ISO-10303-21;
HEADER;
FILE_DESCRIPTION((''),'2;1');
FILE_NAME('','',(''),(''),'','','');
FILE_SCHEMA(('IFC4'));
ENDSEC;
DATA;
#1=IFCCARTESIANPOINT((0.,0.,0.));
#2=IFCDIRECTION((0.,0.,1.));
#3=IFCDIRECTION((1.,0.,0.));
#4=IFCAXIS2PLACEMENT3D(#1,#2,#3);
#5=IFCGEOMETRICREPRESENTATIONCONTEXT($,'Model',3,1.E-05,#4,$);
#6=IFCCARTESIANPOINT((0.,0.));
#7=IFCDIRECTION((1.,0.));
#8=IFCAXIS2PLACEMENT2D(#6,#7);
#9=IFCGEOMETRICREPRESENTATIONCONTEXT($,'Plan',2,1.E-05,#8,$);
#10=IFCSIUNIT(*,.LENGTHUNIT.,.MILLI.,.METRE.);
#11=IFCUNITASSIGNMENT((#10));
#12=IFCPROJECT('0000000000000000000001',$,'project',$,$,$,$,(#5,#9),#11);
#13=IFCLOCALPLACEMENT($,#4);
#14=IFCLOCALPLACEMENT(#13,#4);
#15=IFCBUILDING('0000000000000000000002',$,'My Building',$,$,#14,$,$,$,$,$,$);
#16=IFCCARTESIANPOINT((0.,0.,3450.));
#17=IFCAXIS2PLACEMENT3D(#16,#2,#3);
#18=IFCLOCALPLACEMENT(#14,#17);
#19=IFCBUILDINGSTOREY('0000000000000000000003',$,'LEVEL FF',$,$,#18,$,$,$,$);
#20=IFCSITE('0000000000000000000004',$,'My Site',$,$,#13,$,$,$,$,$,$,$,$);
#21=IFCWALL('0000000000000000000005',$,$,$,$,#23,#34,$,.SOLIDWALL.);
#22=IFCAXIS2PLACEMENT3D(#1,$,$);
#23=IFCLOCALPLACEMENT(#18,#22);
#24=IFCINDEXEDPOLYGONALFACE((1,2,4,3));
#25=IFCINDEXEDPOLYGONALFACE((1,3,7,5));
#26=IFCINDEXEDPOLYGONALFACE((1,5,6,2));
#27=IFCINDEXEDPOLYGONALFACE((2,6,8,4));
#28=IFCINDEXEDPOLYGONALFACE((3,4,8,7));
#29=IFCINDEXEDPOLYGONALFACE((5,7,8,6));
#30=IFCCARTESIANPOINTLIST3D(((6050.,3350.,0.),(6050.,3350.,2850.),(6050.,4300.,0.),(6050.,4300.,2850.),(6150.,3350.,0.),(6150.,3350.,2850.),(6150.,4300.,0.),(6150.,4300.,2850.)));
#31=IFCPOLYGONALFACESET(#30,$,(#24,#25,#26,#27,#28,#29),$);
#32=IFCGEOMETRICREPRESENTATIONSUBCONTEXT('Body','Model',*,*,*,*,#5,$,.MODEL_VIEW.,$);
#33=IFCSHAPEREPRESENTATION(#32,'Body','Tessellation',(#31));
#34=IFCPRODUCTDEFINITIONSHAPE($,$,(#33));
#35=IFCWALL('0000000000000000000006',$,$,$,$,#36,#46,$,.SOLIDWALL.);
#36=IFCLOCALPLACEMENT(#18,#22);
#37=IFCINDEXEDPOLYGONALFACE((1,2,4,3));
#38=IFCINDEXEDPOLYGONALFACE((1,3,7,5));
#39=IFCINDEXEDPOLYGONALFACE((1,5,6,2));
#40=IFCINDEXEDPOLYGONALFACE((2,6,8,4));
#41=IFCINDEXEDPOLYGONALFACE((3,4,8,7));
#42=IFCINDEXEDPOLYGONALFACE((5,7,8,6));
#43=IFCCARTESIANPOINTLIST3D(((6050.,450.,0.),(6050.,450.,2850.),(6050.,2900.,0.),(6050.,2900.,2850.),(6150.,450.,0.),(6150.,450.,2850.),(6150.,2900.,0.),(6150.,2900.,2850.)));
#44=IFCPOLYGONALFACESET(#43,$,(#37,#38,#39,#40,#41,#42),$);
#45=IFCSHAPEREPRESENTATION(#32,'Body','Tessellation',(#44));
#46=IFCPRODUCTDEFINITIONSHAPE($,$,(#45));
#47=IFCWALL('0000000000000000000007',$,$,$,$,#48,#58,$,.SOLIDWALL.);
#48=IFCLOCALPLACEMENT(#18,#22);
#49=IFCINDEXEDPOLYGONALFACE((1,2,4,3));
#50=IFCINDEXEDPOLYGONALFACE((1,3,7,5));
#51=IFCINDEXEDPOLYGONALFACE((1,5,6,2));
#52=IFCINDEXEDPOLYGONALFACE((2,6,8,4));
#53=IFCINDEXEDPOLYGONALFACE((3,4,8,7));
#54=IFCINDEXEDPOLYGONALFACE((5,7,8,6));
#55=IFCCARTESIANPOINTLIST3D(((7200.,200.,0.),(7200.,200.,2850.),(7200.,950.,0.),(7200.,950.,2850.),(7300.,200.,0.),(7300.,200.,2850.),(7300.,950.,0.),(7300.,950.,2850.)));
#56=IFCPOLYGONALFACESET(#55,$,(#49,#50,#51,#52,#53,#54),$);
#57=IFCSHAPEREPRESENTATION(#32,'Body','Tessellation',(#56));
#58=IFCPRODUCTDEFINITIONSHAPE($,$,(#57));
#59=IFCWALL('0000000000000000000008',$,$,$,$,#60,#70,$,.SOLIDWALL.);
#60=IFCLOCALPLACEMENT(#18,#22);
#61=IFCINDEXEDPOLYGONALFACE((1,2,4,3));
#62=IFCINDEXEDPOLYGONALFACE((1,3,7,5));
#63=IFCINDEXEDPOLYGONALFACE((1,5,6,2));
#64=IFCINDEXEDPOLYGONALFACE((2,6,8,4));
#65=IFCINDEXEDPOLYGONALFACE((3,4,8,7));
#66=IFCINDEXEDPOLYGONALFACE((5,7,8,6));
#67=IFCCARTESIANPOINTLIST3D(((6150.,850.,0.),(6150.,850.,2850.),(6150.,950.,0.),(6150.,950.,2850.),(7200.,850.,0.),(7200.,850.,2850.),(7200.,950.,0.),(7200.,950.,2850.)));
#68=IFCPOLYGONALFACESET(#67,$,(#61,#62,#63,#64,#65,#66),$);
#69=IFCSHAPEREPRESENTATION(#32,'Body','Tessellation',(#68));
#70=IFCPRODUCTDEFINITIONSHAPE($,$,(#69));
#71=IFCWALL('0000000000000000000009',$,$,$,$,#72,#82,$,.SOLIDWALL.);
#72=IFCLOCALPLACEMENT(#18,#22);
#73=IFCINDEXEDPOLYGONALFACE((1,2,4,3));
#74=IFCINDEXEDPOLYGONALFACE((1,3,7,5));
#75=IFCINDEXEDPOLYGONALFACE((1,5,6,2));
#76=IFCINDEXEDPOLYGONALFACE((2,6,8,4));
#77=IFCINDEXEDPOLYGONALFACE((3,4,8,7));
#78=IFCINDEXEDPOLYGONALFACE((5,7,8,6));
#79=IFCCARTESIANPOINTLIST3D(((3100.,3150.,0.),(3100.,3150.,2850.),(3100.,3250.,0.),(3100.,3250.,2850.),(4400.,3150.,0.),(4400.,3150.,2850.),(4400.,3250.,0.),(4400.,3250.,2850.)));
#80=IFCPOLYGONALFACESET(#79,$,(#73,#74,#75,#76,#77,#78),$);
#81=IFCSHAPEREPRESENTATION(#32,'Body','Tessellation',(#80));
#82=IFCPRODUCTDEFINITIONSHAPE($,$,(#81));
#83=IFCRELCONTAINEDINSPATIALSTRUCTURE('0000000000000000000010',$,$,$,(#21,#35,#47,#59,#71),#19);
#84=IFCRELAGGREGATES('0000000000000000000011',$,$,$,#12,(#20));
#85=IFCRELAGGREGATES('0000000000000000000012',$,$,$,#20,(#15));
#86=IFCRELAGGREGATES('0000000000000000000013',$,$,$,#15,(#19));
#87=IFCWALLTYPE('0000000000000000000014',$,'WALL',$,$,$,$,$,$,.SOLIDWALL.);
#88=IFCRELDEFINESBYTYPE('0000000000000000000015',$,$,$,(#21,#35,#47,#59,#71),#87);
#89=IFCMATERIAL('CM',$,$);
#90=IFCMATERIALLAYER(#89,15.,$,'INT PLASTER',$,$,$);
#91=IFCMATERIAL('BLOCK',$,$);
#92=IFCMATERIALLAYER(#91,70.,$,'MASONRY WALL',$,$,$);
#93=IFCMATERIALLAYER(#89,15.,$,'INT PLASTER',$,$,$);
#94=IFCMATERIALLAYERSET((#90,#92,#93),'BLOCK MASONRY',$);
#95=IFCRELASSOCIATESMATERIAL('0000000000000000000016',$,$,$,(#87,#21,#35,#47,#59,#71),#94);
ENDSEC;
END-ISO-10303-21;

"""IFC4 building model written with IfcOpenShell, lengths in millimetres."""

from ifc_helpers import new_model, si_unit, frame, origin_with_axes, origin_2d_with_axis, place, context, subcontext, project, spatial, indexed_curve, outline, extrude, material, layer, layer_set, layer_usage, type_object, element, save


model = new_model("IFC4")

# Units and contexts
model_context = context("Model", 3, precision=1e-05, world=origin_with_axes())
plan_context = context("Plan", 2, precision=1e-05, world=origin_2d_with_axis())
body_context = subcontext(model_context, "Body", "Model", "MODEL_VIEW")
ifc_project = project(units=[si_unit("LENGTHUNIT", "METRE", prefix="MILLI")], contexts=[model_context, plan_context])

# Site, building, storey
site_placement = place(None, origin_with_axes())
site = spatial("IfcSite", under=ifc_project, at=site_placement, Name="My Site")
building_placement = place(site_placement, origin_with_axes())
building = spatial("IfcBuilding", under=site, at=building_placement, Name="My Building")
storey_placement = place(building_placement, frame((0.0, 0.0, 3450.0), z_axis=(0.0, 0.0, 1.0), x_axis=(1.0, 0.0, 0.0)))
storey = spatial("IfcBuildingStorey", under=building, at=storey_placement, Name="LEVEL FF")

# Shared definitions
ifc_material_1 = material(Name="CM")
ifc_layer_1 = layer(ifc_material_1, 15.0, Name="INT PLASTER")
ifc_material_2 = material(Name="BLOCK")
ifc_layer_2 = layer(ifc_material_2, 70.0, Name="MASONRY WALL")
ifc_layer_3 = layer(ifc_material_1, 15.0, Name="INT PLASTER")
ifc_layer_set_1 = layer_set([ifc_layer_1, ifc_layer_2, ifc_layer_3], Name="BLOCK MASONRY")
wall_type = type_object("IfcWallType", Name="WALL", PredefinedType="SOLIDWALL", material=ifc_layer_set_1)

# Walls
ifc_layer_usage_1 = layer_usage(ifc_layer_set_1, "AXIS2", "POSITIVE", 0.0)
wall_1_placement = place(storey_placement, frame((6150.0, 3350.0, 0.0), z_axis=(0.0, 0.0, 1.0), x_axis=(0.0, 1.0, 0.0)))
element("IfcWall", 1, at=wall_1_placement, inside=storey, type_object=wall_type, material=ifc_layer_usage_1, PredefinedType="SOLIDWALL", context=body_context, shape_type="SweptSolid", body=[
    extrude(outline(indexed_curve([(0.0, 0.0), (0.0, 100.0), (950.0, 100.0), (950.0, 0.0), (0.0, 0.0)], self_intersect=False)), origin_with_axes(), (0.0, 0.0, 1.0), 2850.0),
])
ifc_layer_usage_2 = layer_usage(ifc_layer_set_1, "AXIS2", "POSITIVE", 0.0)
wall_2_placement = place(storey_placement, frame((6150.0, 450.0, 0.0), z_axis=(0.0, 0.0, 1.0), x_axis=(0.0, 1.0, 0.0)))
element("IfcWall", 2, at=wall_2_placement, inside=storey, type_object=wall_type, material=ifc_layer_usage_2, PredefinedType="SOLIDWALL", context=body_context, shape_type="SweptSolid", body=[
    extrude(outline(indexed_curve([(0.0, 0.0), (0.0, 100.0), (2450.0, 100.0), (2450.0, 0.0), (0.0, 0.0)], self_intersect=False)), origin_with_axes(), (0.0, 0.0, 1.0), 2850.0),
])
ifc_layer_usage_3 = layer_usage(ifc_layer_set_1, "AXIS2", "POSITIVE", 0.0)
wall_3_placement = place(storey_placement, frame((7300.0, 200.0, 0.0), z_axis=(0.0, 0.0, 1.0), x_axis=(0.0, 1.0, 0.0)))
element("IfcWall", 3, at=wall_3_placement, inside=storey, type_object=wall_type, material=ifc_layer_usage_3, PredefinedType="SOLIDWALL", context=body_context, shape_type="SweptSolid", body=[
    extrude(outline(indexed_curve([(0.0, 0.0), (0.0, 100.0), (750.0, 100.0), (750.0, 0.0), (0.0, 0.0)], self_intersect=False)), origin_with_axes(), (0.0, 0.0, 1.0), 2850.0),
])
ifc_layer_usage_4 = layer_usage(ifc_layer_set_1, "AXIS2", "POSITIVE", 0.0)
wall_4_placement = place(storey_placement, frame((6150.0, 950.0, 0.0), z_axis=(0.0, 0.0, 1.0), x_axis=(0.0, -1.0, 0.0)))
element("IfcWall", 4, at=wall_4_placement, inside=storey, type_object=wall_type, material=ifc_layer_usage_4, PredefinedType="SOLIDWALL", context=body_context, shape_type="SweptSolid", body=[
    extrude(outline(indexed_curve([(0.0, 0.0), (0.0, 1050.0), (100.0, 1050.0), (100.0, 0.0), (0.0, 0.0)], self_intersect=False)), origin_with_axes(), (0.0, 0.0, 1.0), 2850.0),
])
ifc_layer_usage_5 = layer_usage(ifc_layer_set_1, "AXIS2", "POSITIVE", 0.0)
wall_5_placement = place(storey_placement, frame((3100.0, 3250.0, 0.0), z_axis=(0.0, 0.0, 1.0), x_axis=(0.0, -1.0, 0.0)))
element("IfcWall", 5, at=wall_5_placement, inside=storey, type_object=wall_type, material=ifc_layer_usage_5, PredefinedType="SOLIDWALL", context=body_context, shape_type="SweptSolid", body=[
    extrude(outline(indexed_curve([(0.0, 0.0), (0.0, 1300.0), (100.0, 1300.0), (100.0, 0.0), (0.0, 0.0)], self_intersect=False)), origin_with_axes(), (0.0, 0.0, 1.0), 2850.0),
])

save(model, "model.ifc")
